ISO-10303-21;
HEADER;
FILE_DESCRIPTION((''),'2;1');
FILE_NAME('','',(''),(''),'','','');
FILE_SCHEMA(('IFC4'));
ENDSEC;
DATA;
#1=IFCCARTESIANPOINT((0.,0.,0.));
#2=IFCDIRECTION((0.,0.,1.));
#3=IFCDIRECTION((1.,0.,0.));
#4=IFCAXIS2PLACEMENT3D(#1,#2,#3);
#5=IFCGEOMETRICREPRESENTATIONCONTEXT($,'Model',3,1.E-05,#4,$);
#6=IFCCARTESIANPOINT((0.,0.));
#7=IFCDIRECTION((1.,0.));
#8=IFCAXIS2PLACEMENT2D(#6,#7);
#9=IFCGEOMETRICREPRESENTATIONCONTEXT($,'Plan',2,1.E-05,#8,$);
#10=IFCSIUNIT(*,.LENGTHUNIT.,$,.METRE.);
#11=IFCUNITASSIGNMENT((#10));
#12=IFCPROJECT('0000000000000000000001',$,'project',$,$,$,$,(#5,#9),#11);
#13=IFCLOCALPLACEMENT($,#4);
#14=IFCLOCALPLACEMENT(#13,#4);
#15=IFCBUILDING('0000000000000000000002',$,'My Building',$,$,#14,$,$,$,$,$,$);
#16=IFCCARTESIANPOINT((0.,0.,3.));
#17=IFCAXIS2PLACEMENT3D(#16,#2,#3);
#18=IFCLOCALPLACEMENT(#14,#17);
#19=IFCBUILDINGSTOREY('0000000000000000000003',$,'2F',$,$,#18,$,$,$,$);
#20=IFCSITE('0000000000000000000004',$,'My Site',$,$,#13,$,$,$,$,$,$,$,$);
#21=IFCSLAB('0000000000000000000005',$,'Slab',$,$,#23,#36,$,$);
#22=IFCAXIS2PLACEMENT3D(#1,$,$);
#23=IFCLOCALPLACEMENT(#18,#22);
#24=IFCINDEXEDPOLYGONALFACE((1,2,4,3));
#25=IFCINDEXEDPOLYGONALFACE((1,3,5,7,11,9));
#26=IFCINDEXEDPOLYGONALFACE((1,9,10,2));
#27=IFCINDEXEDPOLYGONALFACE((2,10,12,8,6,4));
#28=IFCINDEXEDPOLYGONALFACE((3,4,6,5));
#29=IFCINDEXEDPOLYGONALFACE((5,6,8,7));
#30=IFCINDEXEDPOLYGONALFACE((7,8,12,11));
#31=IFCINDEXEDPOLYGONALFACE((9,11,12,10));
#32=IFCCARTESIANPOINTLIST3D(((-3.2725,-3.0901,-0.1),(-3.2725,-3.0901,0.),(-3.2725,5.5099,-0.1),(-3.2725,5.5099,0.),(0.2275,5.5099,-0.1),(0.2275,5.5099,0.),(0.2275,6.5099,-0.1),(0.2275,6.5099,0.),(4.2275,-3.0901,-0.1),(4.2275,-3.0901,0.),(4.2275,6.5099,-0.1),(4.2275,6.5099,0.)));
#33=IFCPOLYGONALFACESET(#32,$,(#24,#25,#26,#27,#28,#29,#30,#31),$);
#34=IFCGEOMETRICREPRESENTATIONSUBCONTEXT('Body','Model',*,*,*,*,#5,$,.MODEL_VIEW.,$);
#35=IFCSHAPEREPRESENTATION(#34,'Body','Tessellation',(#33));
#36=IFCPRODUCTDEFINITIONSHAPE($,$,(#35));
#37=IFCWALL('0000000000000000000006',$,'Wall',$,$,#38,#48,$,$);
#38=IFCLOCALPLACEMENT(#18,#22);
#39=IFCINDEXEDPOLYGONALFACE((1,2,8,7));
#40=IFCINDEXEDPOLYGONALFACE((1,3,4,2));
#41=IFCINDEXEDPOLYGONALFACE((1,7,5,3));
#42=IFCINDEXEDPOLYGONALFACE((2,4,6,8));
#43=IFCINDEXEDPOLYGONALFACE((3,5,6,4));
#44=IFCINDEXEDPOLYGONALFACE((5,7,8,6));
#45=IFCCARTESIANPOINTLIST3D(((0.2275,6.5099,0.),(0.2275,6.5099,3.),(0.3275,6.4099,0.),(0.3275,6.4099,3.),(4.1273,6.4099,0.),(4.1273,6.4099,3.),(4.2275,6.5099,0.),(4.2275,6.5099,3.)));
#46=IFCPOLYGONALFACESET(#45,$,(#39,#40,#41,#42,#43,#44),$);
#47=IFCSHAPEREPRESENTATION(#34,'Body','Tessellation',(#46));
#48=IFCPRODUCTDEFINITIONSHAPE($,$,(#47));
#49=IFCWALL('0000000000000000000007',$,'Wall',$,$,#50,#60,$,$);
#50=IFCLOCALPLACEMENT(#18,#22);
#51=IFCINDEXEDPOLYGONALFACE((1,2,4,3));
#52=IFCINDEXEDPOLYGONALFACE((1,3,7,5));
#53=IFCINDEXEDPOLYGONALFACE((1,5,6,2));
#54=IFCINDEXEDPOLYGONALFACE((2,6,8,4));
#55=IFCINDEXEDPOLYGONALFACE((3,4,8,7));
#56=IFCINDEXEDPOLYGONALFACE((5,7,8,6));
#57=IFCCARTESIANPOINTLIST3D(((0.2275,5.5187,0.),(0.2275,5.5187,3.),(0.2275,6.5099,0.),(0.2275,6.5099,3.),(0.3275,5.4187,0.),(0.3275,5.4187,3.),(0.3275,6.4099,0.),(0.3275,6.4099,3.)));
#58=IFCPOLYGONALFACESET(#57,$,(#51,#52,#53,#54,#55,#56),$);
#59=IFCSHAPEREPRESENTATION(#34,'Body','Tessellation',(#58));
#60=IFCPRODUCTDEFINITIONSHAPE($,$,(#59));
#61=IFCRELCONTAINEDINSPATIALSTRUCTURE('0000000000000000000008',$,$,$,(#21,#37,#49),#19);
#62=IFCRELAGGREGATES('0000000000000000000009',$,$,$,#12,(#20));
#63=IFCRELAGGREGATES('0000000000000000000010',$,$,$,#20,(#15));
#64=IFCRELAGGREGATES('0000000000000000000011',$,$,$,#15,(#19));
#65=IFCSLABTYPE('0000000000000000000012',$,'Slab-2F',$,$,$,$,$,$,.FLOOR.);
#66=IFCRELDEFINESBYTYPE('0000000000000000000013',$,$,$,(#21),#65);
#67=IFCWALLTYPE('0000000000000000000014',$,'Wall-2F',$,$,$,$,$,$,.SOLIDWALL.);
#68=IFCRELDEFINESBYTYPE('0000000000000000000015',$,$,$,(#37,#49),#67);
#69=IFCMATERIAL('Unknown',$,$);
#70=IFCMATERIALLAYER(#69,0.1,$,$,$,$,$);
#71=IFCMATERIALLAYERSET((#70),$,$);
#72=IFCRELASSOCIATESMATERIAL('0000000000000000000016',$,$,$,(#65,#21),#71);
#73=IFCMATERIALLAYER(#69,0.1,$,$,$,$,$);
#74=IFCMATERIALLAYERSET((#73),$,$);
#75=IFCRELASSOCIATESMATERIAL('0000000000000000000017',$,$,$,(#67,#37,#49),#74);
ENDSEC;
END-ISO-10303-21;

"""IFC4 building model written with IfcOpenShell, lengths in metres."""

from ifc_helpers import new_model, si_unit, frame, origin_with_axes, origin_2d_with_axis, place, context, subcontext, project, spatial, line, indexed_curve, outline, extrude, material, layer, layer_set, layer_usage, type_object, element, save


model = new_model("IFC4")

# Units and contexts
model_context = context("Model", 3, precision=1e-05, world=origin_with_axes())
plan_context = context("Plan", 2, precision=1e-05, world=origin_2d_with_axis())
body_context_1 = subcontext(model_context, "Body", "Model", "MODEL_VIEW")
ifc_project = project(units=[si_unit("LENGTHUNIT", "METRE")], contexts=[model_context, plan_context])

# Site, building, storey
site_placement = place(None, origin_with_axes())
site = spatial("IfcSite", under=ifc_project, at=site_placement, Name="My Site")
building_placement = place(site_placement, origin_with_axes())
building = spatial("IfcBuilding", under=site, at=building_placement, Name="My Building")
storey_placement = place(building_placement, frame((0.0, 0.0, 3.0), z_axis=(0.0, 0.0, 1.0), x_axis=(1.0, 0.0, 0.0)))
storey = spatial("IfcBuildingStorey", under=building, at=storey_placement, Name="2F")

# Slab
ifc_material_1 = material(Name="Unknown")
ifc_layer_1 = layer(ifc_material_1, 0.1)
ifc_layer_set_1 = layer_set([ifc_layer_1])
ifc_layer_usage_1 = layer_usage(ifc_layer_set_1, "AXIS3", "POSITIVE", -0.1)
slab_type = type_object("IfcSlabType", Name="Slab-2F", PredefinedType="FLOOR", material=ifc_layer_set_1)
slab_placement = place(storey_placement, frame((4.2275, 6.5099, 0.0), z_axis=(0.0, 0.0, 1.0), x_axis=(1.0, 0.0, 0.0)))
element("IfcSlab", 1, at=slab_placement, inside=storey, type_object=slab_type, material=ifc_layer_usage_1, Name="Slab", context=body_context_1, shape_type="SweptSolid", body=[
    extrude(outline(indexed_curve([(0.0, 0.0), (-4.0, 0.0), (-4.0, -1.0), (-7.5, -1.0), (-7.5, -9.6), (0.0, -9.6), (0.0, 0.0)])), frame((0.0, 0.0, -0.1), z_axis=(0.0, 0.0, 1.0), x_axis=(1.0, 0.0, 0.0)), (0.0, 0.0, 1.0), 0.1),
])

# Walls
ifc_layer_2 = layer(ifc_material_1, 0.1)
ifc_layer_set_2 = layer_set([ifc_layer_2])
ifc_layer_usage_2 = layer_usage(ifc_layer_set_2, "AXIS2", "POSITIVE", 0.0)
wall_type = type_object("IfcWallType", Name="Wall-2F", PredefinedType="SOLIDWALL", material=ifc_layer_set_2)
wall_1_placement = place(storey_placement, frame((4.2275, 6.5099, 0.0), z_axis=(0.0, 0.0, 1.0), x_axis=(-1.0, 0.0, 0.0)))
element("IfcWall", 2, at=wall_1_placement, inside=storey, type_object=wall_type, material=ifc_layer_usage_2, Name="Wall", context=body_context_1, shape_type="SweptSolid", body=[
    extrude(outline(indexed_curve([(0.0, 0.0), (0.1002, 0.1), (3.9, 0.1), (4.0, 0.0)], segments=[line(1, 2, 3, 4, 1)])), origin_with_axes(), (0.0, 0.0, 1.0), 3.0),
])
ifc_layer_usage_3 = layer_usage(ifc_layer_set_2, "AXIS2", "POSITIVE", 0.0)
wall_2_placement = place(storey_placement, frame((0.2275, 6.5099, 0.0), z_axis=(0.0, 0.0, 1.0), x_axis=(0.0, -1.0, 0.0)))
element("IfcWall", 3, at=wall_2_placement, inside=storey, type_object=wall_type, material=ifc_layer_usage_3, Name="Wall", context=body_context_1, shape_type="SweptSolid", body=[
    extrude(outline(indexed_curve([(0.0, 0.0), (0.1, 0.1), (1.0913, 0.1), (0.9913, 0.0)], segments=[line(1, 2, 3, 4, 1)])), origin_with_axes(), (0.0, 0.0, 1.0), 3.0),
])

save(model, "model.ifc")
